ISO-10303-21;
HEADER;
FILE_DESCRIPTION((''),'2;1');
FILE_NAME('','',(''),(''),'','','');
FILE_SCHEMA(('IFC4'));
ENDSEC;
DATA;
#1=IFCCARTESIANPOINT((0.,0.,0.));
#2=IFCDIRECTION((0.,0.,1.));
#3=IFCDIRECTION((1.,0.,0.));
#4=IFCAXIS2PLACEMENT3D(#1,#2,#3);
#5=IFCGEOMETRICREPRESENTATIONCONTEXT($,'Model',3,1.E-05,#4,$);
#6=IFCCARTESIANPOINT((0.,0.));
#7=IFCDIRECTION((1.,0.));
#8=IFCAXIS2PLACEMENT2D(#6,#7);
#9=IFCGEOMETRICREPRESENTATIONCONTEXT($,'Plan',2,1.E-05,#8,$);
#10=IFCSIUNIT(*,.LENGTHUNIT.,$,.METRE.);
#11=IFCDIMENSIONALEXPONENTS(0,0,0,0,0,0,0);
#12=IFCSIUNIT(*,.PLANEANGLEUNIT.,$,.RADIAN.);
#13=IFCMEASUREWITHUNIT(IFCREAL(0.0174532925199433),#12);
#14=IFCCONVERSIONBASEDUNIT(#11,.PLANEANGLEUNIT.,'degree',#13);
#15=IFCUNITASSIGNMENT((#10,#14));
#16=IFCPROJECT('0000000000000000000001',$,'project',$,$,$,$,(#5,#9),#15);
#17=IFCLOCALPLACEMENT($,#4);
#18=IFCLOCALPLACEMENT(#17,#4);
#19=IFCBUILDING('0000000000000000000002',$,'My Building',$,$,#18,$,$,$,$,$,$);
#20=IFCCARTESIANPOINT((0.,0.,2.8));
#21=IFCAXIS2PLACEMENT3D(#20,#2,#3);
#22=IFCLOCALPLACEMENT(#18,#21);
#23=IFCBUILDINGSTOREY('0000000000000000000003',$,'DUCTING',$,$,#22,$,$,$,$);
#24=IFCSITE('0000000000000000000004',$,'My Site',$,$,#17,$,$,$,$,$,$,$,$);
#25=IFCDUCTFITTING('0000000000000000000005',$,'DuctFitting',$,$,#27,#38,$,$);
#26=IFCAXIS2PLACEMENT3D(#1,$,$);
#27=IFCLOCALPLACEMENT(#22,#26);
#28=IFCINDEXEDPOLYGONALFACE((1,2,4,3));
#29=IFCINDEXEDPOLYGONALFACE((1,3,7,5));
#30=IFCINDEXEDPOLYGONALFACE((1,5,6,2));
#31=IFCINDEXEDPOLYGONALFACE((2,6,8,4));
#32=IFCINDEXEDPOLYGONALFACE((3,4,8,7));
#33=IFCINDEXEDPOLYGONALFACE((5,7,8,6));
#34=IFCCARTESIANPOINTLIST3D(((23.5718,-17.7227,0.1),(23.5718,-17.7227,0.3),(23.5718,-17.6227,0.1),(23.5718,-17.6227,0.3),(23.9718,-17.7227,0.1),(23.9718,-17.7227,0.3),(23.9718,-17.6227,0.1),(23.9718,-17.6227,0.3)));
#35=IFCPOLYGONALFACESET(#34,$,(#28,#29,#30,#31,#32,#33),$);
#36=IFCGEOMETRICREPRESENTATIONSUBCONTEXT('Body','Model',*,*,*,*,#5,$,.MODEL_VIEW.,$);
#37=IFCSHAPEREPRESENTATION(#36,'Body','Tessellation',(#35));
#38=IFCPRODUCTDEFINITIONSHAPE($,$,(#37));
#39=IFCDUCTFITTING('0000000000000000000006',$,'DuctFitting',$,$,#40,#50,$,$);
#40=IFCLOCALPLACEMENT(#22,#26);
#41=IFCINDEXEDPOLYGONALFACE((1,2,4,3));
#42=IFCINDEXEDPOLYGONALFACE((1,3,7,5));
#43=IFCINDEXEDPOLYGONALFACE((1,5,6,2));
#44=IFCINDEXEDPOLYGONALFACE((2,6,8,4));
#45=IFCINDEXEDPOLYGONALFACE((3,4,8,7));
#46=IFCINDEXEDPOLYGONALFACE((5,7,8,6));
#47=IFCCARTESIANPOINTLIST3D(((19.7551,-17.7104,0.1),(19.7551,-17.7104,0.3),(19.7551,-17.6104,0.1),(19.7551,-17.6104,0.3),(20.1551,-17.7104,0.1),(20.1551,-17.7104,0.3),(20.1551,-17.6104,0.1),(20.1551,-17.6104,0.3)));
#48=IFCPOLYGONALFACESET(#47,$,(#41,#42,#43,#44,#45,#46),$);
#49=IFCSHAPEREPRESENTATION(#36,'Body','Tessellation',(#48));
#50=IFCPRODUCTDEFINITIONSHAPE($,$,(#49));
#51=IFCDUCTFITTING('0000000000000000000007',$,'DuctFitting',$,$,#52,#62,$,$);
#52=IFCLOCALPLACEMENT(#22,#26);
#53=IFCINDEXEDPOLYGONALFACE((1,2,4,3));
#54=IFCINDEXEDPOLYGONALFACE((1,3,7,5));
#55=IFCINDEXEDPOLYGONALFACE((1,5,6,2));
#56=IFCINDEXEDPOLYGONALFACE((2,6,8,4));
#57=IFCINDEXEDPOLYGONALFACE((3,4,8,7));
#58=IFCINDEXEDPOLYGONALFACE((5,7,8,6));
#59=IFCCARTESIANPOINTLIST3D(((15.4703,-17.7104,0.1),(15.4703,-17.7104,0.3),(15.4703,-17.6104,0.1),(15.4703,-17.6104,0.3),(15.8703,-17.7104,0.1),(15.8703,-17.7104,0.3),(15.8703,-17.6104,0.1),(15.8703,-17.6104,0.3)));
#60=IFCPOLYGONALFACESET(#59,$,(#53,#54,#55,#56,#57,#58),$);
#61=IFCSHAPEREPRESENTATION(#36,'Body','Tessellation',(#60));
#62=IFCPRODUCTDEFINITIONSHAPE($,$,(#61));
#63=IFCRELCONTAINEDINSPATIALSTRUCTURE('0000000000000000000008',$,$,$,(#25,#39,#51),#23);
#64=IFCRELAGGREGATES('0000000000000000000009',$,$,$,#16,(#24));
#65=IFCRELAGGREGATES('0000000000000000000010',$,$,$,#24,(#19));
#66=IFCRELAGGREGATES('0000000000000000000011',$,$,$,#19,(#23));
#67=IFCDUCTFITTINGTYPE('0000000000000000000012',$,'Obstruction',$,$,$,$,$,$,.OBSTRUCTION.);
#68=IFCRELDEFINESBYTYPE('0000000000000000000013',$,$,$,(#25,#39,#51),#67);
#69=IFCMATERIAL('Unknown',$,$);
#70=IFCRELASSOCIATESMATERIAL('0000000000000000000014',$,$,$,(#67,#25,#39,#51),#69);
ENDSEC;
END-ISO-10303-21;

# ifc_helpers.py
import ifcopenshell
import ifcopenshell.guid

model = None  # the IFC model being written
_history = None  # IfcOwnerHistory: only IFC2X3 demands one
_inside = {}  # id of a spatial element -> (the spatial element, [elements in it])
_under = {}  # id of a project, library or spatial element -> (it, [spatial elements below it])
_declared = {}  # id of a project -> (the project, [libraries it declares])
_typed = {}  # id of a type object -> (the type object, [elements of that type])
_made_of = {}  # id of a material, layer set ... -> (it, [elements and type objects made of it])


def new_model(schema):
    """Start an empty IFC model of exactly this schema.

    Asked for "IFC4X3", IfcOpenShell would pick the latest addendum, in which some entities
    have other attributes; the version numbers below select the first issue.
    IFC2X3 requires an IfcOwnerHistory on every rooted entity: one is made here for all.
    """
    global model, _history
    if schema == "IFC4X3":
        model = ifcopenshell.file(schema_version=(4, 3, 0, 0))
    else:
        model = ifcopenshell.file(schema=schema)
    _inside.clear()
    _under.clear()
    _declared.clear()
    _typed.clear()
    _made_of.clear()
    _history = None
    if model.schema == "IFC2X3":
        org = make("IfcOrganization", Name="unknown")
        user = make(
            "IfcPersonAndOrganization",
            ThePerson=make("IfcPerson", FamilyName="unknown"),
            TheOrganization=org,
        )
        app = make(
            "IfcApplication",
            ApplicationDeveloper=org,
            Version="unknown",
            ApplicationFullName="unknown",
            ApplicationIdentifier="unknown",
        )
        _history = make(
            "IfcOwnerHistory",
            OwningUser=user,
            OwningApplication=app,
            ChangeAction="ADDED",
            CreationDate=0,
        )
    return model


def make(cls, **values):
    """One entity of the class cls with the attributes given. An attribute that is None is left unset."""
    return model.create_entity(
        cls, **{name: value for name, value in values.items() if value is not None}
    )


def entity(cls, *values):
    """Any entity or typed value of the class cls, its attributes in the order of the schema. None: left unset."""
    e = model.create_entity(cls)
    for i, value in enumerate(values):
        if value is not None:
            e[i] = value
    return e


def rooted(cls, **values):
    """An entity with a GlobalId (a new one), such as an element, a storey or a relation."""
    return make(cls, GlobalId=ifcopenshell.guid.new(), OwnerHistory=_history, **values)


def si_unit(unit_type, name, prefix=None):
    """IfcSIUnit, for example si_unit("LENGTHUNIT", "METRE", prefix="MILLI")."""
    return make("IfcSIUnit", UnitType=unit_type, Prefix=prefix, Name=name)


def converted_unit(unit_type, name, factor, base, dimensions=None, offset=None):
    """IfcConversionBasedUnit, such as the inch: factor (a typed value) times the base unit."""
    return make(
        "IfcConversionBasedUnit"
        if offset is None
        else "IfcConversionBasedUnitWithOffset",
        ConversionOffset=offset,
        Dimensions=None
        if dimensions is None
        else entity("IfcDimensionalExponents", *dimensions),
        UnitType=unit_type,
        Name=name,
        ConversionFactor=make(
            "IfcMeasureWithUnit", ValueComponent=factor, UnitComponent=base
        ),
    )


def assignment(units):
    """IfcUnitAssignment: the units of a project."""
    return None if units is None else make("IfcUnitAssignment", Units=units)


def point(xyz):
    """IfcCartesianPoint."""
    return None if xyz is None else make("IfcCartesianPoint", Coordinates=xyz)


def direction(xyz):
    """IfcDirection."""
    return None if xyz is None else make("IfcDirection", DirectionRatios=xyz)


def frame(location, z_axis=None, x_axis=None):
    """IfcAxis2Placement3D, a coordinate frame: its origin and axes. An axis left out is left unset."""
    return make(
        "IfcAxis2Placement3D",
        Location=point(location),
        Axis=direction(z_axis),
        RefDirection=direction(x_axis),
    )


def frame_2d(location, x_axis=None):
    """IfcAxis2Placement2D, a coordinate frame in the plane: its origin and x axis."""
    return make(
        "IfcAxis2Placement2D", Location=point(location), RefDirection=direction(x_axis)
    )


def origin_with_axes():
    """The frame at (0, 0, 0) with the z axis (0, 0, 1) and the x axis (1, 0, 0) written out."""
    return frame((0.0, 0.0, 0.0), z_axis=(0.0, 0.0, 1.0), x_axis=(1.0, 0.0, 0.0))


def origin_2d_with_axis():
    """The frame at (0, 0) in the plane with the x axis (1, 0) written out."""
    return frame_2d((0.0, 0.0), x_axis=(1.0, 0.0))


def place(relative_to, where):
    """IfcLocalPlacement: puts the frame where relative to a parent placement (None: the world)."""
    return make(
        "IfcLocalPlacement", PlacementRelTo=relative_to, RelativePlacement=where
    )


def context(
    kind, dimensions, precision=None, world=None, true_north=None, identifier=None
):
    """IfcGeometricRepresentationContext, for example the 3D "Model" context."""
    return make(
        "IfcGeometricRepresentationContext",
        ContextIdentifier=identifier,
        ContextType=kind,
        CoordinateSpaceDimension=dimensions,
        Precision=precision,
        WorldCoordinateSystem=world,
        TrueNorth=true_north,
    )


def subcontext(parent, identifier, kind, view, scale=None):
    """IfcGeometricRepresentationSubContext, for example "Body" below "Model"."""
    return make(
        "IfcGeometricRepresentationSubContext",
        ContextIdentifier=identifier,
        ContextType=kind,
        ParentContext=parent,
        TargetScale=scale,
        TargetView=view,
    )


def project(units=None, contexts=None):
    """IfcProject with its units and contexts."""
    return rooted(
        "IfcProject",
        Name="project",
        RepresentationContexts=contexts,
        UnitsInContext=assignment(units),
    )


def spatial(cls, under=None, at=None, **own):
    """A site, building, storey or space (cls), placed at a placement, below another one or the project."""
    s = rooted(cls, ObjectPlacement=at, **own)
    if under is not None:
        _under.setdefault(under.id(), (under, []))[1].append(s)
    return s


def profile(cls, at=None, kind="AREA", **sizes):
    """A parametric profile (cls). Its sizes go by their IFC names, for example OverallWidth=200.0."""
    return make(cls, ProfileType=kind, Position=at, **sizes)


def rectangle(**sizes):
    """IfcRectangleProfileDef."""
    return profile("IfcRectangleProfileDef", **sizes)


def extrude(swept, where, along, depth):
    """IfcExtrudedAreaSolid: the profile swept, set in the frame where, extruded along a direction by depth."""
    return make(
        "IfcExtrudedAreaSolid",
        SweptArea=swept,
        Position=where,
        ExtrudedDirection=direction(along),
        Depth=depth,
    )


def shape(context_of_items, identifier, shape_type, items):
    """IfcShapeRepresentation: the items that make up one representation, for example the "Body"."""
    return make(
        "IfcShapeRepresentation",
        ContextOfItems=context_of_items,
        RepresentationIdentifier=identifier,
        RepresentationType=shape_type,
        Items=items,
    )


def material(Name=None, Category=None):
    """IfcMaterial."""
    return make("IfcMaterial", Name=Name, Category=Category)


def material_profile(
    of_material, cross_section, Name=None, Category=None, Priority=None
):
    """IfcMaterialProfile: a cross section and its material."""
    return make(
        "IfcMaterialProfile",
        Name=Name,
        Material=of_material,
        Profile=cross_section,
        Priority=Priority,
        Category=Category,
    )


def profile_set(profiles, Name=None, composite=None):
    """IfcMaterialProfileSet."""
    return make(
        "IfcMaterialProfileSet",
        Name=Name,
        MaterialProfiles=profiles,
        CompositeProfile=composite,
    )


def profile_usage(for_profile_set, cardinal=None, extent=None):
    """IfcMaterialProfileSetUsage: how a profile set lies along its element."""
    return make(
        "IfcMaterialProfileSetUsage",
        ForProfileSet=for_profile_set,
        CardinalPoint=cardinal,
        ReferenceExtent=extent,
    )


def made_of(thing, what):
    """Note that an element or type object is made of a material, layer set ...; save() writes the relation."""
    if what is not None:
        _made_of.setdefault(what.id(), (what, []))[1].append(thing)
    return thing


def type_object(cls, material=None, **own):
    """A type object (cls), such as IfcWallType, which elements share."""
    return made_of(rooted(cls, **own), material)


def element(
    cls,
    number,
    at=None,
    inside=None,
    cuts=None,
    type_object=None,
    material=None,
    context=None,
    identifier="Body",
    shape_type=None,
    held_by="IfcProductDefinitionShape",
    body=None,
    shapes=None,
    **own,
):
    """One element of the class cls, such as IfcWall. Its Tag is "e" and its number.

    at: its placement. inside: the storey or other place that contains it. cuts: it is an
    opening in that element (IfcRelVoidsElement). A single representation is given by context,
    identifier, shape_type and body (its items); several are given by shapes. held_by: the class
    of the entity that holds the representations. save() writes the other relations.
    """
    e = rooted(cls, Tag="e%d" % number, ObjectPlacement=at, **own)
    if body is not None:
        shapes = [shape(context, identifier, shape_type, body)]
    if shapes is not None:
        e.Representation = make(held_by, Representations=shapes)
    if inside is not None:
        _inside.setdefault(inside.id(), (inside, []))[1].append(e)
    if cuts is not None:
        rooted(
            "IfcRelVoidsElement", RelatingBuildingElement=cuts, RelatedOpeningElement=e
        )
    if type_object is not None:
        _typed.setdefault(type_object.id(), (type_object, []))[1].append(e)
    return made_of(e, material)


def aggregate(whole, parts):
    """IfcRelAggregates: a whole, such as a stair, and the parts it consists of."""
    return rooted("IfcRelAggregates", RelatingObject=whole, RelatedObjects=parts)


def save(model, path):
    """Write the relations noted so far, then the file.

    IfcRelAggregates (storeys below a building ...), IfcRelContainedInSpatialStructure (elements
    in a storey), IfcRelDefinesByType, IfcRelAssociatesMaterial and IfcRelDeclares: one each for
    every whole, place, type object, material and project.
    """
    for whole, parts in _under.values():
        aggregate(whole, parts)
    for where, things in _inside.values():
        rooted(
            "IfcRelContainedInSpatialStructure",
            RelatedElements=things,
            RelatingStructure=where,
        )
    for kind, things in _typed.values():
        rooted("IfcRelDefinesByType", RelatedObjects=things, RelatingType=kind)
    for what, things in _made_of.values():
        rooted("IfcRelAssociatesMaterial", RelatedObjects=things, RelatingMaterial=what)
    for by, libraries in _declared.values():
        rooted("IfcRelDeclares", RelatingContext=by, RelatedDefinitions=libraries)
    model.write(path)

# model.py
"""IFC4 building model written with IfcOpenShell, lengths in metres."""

from ifc_helpers import new_model, entity, si_unit, converted_unit, frame, origin_with_axes, origin_2d_with_axis, place, context, subcontext, project, spatial, rectangle, extrude, material, material_profile, profile_set, profile_usage, type_object, element, save


model = new_model("IFC4")

# Units and contexts
model_context = context("Model", 3, precision=1e-05, world=origin_with_axes())
plan_context = context("Plan", 2, precision=1e-05, world=origin_2d_with_axis())
body_context = subcontext(model_context, "Body", "Model", "MODEL_VIEW")
ifc_project = project(units=[si_unit("LENGTHUNIT", "METRE"), converted_unit("PLANEANGLEUNIT", "degree", entity("IfcReal", 0.0174532925199433), si_unit("PLANEANGLEUNIT", "RADIAN"), dimensions=[0, 0, 0, 0, 0, 0, 0])], contexts=[model_context, plan_context])

# Site, building, storey
site_placement = place(None, origin_with_axes())
site = spatial("IfcSite", under=ifc_project, at=site_placement, Name="My Site")
building_placement = place(site_placement, origin_with_axes())
building = spatial("IfcBuilding", under=site, at=building_placement, Name="My Building")
storey_placement = place(building_placement, frame((0.0, 0.0, 2.8), z_axis=(0.0, 0.0, 1.0), x_axis=(1.0, 0.0, 0.0)))
storey = spatial("IfcBuildingStorey", under=building, at=storey_placement, Name="DUCTING")

# Shared definitions
ifc_material = material(Name="Unknown")

# Duct fittings
ifc_material_profile_1 = material_profile(ifc_material, rectangle(XDim=0.4, YDim=0.2))
ifc_profile_set_1 = profile_set([ifc_material_profile_1])
duct_fitting_type_1 = type_object("IfcDuctFittingType", Name="Obstruction", PredefinedType="OBSTRUCTION", material=ifc_profile_set_1)
ifc_profile_usage_1 = profile_usage(ifc_profile_set_1, cardinal=5)
duct_fitting_1_placement = place(storey_placement, frame((23.7718, -17.7227, 0.2), z_axis=(0.0, 1.0, 0.0), x_axis=(1.0, 0.0, 0.0)))
element("IfcDuctFitting", 1, at=duct_fitting_1_placement, inside=storey, type_object=duct_fitting_type_1, material=ifc_profile_usage_1, Name="DuctFitting", context=body_context, shape_type="SweptSolid", body=[
    extrude(rectangle(XDim=0.4, YDim=0.2), origin_with_axes(), (0.0, 0.0, 1.0), 0.1),
])
ifc_profile_usage_2 = profile_usage(ifc_profile_set_1, cardinal=5)
duct_fitting_2_placement = place(storey_placement, frame((19.9551, -17.7104, 0.2), z_axis=(0.0, 1.0, 0.0), x_axis=(1.0, 0.0, 0.0)))
element("IfcDuctFitting", 2, at=duct_fitting_2_placement, inside=storey, type_object=duct_fitting_type_1, material=ifc_profile_usage_2, Name="DuctFitting", context=body_context, shape_type="SweptSolid", body=[
    extrude(rectangle(XDim=0.4, YDim=0.2), origin_with_axes(), (0.0, 0.0, 1.0), 0.1),
])
ifc_profile_usage_3 = profile_usage(ifc_profile_set_1, cardinal=5)
duct_fitting_3_placement = place(storey_placement, frame((15.6703, -17.7104, 0.2), z_axis=(0.0, 1.0, 0.0), x_axis=(1.0, 0.0, 0.0)))
element("IfcDuctFitting", 3, at=duct_fitting_3_placement, inside=storey, type_object=duct_fitting_type_1, material=ifc_profile_usage_3, Name="DuctFitting", context=body_context, shape_type="SweptSolid", body=[
    extrude(rectangle(XDim=0.4, YDim=0.2), origin_with_axes(), (0.0, 0.0, 1.0), 0.1),
])

save(model, "model.ifc")
